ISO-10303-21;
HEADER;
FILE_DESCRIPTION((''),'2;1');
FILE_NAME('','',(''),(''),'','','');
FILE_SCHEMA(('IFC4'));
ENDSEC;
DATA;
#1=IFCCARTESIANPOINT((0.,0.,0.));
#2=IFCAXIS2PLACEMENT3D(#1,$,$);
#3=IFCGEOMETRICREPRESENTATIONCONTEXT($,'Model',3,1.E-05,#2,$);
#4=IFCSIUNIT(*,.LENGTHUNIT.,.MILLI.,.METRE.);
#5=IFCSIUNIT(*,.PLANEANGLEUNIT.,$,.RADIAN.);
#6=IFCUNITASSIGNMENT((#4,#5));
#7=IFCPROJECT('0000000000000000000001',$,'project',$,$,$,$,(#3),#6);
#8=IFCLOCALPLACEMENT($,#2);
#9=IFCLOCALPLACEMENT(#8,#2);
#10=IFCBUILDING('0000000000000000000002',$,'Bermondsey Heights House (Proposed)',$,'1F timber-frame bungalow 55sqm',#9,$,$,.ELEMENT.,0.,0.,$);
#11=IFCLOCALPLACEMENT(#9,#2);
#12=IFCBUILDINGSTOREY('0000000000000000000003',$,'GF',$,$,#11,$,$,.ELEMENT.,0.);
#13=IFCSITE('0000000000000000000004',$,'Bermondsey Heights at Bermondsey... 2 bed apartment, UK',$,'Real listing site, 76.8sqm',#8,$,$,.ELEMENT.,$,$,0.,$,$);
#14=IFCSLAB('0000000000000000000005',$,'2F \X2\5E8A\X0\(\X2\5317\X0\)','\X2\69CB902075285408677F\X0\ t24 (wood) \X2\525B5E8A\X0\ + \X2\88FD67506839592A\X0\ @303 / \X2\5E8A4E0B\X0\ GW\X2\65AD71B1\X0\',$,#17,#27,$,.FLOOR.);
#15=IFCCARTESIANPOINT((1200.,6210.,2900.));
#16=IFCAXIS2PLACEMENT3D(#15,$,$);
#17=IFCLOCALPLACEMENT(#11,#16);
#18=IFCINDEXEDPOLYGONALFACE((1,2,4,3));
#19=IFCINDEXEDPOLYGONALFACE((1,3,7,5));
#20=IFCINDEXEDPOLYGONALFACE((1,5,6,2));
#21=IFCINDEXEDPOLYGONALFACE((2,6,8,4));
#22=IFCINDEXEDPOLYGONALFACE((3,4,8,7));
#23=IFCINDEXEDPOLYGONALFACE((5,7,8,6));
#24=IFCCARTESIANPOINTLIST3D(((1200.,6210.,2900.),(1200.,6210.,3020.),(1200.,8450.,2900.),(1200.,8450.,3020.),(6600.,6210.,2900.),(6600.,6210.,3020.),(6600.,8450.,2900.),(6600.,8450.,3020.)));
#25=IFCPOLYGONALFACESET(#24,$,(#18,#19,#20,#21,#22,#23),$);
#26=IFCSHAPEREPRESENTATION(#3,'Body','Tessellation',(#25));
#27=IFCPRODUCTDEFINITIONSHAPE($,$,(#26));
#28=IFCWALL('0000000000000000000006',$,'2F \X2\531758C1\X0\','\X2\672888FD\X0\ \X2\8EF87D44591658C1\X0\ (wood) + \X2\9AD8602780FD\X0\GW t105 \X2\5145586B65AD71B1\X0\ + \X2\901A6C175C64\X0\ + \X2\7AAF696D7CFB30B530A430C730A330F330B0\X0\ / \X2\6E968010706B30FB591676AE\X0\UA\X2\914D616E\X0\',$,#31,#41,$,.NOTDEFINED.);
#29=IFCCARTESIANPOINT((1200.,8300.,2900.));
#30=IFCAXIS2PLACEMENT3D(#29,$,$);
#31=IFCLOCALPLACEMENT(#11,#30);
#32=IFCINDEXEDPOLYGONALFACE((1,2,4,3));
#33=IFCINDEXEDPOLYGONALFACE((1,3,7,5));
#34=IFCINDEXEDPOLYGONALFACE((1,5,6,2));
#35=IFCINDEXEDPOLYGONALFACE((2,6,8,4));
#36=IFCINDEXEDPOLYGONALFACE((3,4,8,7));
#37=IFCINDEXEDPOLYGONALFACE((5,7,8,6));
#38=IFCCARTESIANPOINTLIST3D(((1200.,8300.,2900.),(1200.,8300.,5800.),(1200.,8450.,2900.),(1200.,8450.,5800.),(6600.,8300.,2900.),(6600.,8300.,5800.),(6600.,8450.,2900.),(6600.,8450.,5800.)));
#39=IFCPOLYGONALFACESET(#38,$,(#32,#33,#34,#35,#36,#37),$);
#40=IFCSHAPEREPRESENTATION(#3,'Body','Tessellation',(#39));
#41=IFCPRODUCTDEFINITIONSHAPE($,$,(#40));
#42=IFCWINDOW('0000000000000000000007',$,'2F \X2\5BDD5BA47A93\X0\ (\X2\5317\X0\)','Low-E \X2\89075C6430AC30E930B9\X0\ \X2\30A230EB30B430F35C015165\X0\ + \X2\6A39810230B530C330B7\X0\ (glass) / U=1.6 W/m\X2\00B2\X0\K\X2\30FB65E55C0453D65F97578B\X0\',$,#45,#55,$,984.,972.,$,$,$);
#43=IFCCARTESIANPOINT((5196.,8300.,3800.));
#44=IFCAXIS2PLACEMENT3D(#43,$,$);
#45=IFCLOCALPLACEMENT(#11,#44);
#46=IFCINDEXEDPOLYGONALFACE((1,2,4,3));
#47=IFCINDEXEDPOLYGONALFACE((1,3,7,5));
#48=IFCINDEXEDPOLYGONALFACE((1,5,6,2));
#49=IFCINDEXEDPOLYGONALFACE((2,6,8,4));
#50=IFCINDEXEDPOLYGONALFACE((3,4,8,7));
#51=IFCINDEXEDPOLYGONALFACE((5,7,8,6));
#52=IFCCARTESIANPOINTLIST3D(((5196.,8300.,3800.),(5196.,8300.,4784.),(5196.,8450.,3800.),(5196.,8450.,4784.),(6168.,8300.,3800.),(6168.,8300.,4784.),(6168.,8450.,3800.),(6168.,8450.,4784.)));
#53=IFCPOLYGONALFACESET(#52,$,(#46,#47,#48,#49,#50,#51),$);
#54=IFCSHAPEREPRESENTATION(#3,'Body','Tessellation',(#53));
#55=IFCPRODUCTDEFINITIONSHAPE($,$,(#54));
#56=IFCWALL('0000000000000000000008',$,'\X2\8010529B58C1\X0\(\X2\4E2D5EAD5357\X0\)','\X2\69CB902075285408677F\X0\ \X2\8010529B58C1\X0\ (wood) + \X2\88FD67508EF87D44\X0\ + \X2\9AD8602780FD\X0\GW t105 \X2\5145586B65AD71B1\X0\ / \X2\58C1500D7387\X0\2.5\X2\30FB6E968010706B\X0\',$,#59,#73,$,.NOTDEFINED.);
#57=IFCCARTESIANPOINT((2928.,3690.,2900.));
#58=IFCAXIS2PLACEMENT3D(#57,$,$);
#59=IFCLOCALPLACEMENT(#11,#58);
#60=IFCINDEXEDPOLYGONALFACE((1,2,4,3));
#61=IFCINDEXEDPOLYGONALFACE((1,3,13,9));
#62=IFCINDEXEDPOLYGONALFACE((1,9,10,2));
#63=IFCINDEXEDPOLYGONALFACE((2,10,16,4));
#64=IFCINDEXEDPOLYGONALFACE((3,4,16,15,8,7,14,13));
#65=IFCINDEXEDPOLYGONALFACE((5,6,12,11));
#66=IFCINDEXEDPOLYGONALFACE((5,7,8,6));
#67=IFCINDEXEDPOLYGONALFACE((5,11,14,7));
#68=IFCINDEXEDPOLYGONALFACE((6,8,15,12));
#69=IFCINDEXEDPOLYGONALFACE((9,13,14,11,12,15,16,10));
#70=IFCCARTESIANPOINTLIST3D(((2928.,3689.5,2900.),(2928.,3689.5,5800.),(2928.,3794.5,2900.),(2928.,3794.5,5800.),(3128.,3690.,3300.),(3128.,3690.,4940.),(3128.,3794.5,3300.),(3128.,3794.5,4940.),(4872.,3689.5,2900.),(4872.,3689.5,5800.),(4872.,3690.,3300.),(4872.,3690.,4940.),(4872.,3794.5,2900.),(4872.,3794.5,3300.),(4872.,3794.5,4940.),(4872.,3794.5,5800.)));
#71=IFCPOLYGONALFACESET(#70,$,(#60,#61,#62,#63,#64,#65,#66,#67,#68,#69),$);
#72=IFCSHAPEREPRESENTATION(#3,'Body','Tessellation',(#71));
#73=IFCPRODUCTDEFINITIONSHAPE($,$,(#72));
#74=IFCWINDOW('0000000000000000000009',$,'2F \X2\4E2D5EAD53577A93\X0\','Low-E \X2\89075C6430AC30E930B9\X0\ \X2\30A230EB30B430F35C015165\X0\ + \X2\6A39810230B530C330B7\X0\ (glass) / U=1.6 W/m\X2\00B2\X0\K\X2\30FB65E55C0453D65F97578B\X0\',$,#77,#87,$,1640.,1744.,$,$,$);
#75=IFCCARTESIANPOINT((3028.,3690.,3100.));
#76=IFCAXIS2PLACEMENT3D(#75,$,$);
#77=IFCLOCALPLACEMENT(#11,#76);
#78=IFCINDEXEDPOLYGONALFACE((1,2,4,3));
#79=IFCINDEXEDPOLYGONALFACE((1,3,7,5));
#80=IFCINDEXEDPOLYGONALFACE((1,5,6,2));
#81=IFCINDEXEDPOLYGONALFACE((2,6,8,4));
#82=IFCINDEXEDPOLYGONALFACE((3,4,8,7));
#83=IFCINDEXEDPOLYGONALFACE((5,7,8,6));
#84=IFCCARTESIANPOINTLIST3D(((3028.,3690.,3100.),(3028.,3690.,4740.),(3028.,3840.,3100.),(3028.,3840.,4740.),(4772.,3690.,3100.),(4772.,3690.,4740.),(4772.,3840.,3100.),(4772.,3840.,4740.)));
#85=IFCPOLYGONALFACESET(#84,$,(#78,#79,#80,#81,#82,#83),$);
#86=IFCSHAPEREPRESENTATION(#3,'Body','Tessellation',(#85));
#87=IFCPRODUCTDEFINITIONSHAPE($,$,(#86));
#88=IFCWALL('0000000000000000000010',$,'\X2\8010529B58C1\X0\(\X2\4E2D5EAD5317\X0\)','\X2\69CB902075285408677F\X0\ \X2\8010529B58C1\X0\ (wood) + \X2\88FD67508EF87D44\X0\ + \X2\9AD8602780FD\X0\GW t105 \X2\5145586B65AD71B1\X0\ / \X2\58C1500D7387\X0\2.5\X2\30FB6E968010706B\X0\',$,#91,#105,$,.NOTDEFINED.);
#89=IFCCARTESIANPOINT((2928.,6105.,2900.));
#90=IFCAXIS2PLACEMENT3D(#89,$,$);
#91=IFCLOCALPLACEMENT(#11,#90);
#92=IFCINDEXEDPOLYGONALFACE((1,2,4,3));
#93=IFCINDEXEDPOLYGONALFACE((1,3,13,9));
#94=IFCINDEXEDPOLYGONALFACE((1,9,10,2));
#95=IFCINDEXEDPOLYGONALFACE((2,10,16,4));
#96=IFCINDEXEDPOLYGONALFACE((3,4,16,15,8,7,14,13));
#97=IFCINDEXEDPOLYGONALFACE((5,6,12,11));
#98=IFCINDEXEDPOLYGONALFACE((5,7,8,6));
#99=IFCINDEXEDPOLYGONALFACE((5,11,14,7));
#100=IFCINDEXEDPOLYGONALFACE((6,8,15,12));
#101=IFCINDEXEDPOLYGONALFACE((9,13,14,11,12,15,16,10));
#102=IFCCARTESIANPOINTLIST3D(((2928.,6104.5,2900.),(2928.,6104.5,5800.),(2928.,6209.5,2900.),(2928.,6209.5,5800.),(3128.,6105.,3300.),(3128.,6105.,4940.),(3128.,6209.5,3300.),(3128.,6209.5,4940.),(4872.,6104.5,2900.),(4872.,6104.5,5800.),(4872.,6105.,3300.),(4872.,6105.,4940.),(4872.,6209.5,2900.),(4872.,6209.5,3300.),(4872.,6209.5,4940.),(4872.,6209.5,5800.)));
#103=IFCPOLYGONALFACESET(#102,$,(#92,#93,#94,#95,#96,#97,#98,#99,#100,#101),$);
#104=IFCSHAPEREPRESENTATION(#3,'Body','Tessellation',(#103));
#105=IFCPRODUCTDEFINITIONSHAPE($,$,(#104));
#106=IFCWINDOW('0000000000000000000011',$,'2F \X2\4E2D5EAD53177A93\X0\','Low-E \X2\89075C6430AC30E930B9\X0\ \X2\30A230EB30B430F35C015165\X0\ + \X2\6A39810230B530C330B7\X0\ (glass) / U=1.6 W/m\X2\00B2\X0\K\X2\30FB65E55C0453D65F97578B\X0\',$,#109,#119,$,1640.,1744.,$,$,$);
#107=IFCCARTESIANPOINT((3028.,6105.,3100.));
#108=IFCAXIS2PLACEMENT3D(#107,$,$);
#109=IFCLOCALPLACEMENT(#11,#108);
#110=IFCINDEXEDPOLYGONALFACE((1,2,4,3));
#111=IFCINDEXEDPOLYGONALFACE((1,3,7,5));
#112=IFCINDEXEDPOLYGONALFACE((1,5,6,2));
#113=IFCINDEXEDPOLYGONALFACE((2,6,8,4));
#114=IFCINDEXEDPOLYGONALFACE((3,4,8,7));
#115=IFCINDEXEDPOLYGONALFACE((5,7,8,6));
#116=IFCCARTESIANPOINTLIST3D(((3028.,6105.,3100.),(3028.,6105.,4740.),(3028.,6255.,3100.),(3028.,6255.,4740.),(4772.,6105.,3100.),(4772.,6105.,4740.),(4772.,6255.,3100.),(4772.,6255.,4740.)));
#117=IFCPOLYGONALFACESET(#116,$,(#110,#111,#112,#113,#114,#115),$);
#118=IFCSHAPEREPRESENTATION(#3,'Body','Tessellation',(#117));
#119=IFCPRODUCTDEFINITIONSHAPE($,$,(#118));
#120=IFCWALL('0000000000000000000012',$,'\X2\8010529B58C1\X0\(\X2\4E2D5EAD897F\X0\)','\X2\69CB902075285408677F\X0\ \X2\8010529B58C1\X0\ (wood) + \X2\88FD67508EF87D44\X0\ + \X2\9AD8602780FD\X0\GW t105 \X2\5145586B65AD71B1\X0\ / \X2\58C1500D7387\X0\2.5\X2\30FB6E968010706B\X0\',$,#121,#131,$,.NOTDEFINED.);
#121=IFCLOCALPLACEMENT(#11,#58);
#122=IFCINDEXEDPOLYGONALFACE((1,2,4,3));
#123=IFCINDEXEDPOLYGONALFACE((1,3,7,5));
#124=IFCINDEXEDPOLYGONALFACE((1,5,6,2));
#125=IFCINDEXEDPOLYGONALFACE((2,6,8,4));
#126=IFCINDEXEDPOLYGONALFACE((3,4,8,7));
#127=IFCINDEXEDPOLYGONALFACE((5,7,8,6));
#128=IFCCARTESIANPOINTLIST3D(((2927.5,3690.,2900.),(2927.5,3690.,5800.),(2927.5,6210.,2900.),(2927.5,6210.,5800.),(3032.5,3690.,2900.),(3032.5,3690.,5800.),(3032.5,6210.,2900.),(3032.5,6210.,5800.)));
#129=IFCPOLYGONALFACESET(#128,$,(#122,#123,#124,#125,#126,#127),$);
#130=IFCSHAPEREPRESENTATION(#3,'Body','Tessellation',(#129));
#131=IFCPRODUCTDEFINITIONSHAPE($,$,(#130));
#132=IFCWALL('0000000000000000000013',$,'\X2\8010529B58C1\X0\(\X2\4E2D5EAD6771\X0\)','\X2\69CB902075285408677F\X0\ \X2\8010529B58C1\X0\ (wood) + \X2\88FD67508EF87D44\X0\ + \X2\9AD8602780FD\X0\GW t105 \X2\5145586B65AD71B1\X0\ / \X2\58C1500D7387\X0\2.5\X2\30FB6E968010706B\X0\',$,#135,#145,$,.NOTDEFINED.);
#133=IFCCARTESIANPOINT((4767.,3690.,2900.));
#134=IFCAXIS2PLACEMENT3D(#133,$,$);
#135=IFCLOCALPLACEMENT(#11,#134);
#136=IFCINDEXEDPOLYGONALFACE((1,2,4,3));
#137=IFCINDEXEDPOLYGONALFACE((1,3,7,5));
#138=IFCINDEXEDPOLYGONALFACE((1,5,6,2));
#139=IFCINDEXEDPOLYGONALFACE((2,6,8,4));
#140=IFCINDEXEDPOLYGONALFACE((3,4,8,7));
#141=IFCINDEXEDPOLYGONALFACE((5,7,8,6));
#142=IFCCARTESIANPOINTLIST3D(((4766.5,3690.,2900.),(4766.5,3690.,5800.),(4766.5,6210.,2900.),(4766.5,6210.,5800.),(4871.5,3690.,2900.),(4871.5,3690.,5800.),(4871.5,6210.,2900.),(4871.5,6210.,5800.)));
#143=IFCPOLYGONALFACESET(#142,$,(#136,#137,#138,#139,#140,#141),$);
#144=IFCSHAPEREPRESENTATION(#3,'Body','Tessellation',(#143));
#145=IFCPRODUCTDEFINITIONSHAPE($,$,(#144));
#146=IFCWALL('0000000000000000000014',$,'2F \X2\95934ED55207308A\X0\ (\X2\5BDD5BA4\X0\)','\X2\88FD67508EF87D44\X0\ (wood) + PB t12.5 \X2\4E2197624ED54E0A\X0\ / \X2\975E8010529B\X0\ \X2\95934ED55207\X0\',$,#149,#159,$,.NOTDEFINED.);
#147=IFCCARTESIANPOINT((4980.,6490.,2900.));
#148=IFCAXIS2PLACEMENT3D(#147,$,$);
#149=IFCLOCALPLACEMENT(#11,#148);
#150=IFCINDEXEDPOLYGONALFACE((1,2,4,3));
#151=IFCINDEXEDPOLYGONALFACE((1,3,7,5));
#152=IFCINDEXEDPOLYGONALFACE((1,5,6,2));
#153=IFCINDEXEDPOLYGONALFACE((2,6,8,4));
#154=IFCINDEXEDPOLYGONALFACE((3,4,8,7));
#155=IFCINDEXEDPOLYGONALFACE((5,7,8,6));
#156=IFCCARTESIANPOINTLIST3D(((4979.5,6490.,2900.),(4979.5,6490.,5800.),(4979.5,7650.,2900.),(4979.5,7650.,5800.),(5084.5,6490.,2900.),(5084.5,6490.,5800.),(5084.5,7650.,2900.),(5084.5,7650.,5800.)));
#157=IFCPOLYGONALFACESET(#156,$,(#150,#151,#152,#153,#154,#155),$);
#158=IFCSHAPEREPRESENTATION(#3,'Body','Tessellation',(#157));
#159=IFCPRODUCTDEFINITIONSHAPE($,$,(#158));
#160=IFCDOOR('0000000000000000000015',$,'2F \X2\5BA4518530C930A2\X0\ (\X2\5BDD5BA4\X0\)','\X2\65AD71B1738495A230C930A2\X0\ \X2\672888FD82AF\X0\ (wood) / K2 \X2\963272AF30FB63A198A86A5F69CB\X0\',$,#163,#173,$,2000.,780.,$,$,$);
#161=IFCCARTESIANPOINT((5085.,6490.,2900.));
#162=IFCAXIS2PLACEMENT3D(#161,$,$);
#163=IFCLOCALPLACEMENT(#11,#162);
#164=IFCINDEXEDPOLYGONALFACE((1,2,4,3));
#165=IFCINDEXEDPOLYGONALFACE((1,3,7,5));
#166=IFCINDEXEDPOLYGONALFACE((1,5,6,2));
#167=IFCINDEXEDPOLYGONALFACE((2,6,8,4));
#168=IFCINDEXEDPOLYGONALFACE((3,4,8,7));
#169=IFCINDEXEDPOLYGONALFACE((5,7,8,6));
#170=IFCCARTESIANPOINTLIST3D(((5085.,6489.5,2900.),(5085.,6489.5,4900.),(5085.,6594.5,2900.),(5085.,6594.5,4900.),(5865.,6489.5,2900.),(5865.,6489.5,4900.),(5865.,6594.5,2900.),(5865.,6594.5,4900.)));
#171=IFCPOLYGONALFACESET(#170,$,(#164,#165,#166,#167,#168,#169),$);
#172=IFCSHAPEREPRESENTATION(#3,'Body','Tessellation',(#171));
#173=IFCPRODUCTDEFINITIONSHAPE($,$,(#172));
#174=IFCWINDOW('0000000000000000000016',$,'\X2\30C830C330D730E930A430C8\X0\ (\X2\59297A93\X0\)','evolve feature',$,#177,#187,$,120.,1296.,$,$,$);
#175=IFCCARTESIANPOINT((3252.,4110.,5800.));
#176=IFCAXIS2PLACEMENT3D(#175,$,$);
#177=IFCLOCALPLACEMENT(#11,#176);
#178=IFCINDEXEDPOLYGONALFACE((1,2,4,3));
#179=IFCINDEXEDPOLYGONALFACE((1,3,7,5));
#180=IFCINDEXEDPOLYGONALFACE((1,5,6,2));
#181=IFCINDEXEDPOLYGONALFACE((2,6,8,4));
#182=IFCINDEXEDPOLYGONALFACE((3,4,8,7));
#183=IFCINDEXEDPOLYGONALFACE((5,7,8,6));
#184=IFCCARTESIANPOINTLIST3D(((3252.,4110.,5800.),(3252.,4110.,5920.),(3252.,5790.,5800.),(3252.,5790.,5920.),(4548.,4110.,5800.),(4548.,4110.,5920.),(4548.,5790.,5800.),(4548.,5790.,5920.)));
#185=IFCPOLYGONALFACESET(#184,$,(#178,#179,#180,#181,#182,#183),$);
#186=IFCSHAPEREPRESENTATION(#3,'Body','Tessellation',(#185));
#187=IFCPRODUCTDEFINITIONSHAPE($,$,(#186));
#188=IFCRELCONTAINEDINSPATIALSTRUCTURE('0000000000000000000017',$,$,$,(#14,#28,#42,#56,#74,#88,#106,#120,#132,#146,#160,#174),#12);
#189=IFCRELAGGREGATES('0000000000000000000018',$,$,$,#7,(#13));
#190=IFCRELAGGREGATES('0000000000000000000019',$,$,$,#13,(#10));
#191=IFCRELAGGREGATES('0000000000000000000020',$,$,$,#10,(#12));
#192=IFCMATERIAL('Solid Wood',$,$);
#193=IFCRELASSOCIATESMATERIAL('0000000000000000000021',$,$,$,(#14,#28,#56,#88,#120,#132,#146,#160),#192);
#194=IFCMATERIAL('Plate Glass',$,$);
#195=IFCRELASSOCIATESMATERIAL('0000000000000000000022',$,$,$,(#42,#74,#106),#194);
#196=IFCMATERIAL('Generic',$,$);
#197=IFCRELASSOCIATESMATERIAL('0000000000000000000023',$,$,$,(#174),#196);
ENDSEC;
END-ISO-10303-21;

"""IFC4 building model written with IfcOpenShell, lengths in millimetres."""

from ifc_helpers import new_model, si_unit, frame, frame_2d, origin, place, context, project, spatial, rectangle, extrude, material, element, fill, save


model = new_model("IFC4")

# Units and contexts
model_context = context("Model", 3, precision=1e-05, world=origin())
ifc_project = project(units=[si_unit("LENGTHUNIT", "METRE", prefix="MILLI"), si_unit("PLANEANGLEUNIT", "RADIAN")], contexts=[model_context])

# Site, building, storey
site_placement = place(None, origin())
site = spatial("IfcSite", under=ifc_project, at=site_placement, Name="Bermondsey Heights at Bermondsey... 2 bed apartment, UK", ObjectType="Real listing site, 76.8sqm", CompositionType="ELEMENT", RefElevation=0.0)
building_placement = place(site_placement, origin())
building = spatial("IfcBuilding", under=site, at=building_placement, Name="Bermondsey Heights House (Proposed)", ObjectType="1F timber-frame bungalow 55sqm", CompositionType="ELEMENT", ElevationOfRefHeight=0.0, ElevationOfTerrain=0.0)
storey_placement = place(building_placement, origin())
storey = spatial("IfcBuildingStorey", under=building, at=storey_placement, Name="GF", CompositionType="ELEMENT", Elevation=0.0)

# Slab
ifc_material_1 = material(Name="Solid Wood")
slab_placement = place(storey_placement, frame((1200.0, 6210.0, 2900.0)))
element("IfcSlab", 1, at=slab_placement, inside=storey, material=ifc_material_1, Name="2F 床(北)", Description="構造用合板 t24 (wood) 剛床 + 製材根太 @303 / 床下 GW断熱", PredefinedType="FLOOR", context=model_context, shape_type="SweptSolid", body=[
    extrude(rectangle(XDim=5400.0, YDim=2240.0, at=frame_2d((2700.0, 1120.0))), frame((1200.0, 6210.0, 2900.0)), (0.0, 0.0, 1.0), 120.0),
])

# Walls, openings, windows
wall_1_placement = place(storey_placement, frame((1200.0, 8300.0, 2900.0)))
wall_1 = element("IfcWall", 2, at=wall_1_placement, inside=storey, material=ifc_material_1, Name="2F 北壁", Description="木製 軸組外壁 (wood) + 高性能GW t105 充填断熱 + 通気層 + 窯業系サイディング / 準耐火・外皮UA配慮", PredefinedType="NOTDEFINED", context=model_context, shape_type="SweptSolid", body=[
    extrude(rectangle(XDim=5400.0, YDim=150.0, at=frame_2d((2700.0, 75.0))), frame((1200.0, 8300.0, 2900.0)), (0.0, 0.0, 1.0), 2900.0),
])
opening_1_placement = place(storey_placement, frame((5196.0, 8300.0, 3800.0)))
opening_1 = element("IfcOpeningElement", 3, at=opening_1_placement, cuts=wall_1, PredefinedType="NOTDEFINED", context=model_context, shape_type="SweptSolid", body=[
    extrude(rectangle(XDim=972.0, YDim=150.0, at=frame_2d((486.0, 75.0))), frame((5196.0, 8300.0, 3800.0)), (0.0, 0.0, 1.0), 984.0),
])
ifc_material_2 = material(Name="Plate Glass")
window_1_placement = place(storey_placement, frame((5196.0, 8300.0, 3800.0)))
window_1 = element("IfcWindow", 4, at=window_1_placement, inside=storey, material=ifc_material_2, Name="2F 寝室窓 (北)", Description="Low-E 複層ガラス アルゴン封入 + 樹脂サッシ (glass) / U=1.6 W/m²K・日射取得型", OverallHeight=984.0, OverallWidth=972.0, context=model_context, shape_type="SweptSolid", body=[
    extrude(rectangle(XDim=972.0, YDim=150.0, at=frame_2d((486.0, 75.0))), frame((5196.0, 8300.0, 3800.0)), (0.0, 0.0, 1.0), 984.0),
])
fill(opening_1, window_1)
wall_2_placement = place(storey_placement, frame((2928.0, 3690.0, 2900.0)))
wall_2 = element("IfcWall", 5, at=wall_2_placement, inside=storey, material=ifc_material_1, Name="耐力壁(中庭南)", Description="構造用合板 耐力壁 (wood) + 製材軸組 + 高性能GW t105 充填断熱 / 壁倍率2.5・準耐火", PredefinedType="NOTDEFINED", context=model_context, shape_type="SweptSolid", body=[
    extrude(rectangle(XDim=1944.0, YDim=105.0, at=frame_2d((972.0, 52.0))), frame((2928.0, 3690.0, 2900.0)), (0.0, 0.0, 1.0), 2900.0),
])
opening_2_placement = place(storey_placement, frame((3028.0, 3690.0, 3100.0)))
opening_2 = element("IfcOpeningElement", 6, at=opening_2_placement, cuts=wall_2, PredefinedType="NOTDEFINED", context=model_context, shape_type="SweptSolid", body=[
    extrude(rectangle(XDim=1744.0, YDim=150.0, at=frame_2d((872.0, 75.0))), frame((3028.0, 3690.0, 3100.0)), (0.0, 0.0, 1.0), 1640.0),
])
window_2_placement = place(storey_placement, frame((3028.0, 3690.0, 3100.0)))
window_2 = element("IfcWindow", 7, at=window_2_placement, inside=storey, material=ifc_material_2, Name="2F 中庭南窓", Description="Low-E 複層ガラス アルゴン封入 + 樹脂サッシ (glass) / U=1.6 W/m²K・日射取得型", OverallHeight=1640.0, OverallWidth=1744.0, context=model_context, shape_type="SweptSolid", body=[
    extrude(rectangle(XDim=1744.0, YDim=150.0, at=frame_2d((872.0, 75.0))), frame((3028.0, 3690.0, 3100.0)), (0.0, 0.0, 1.0), 1640.0),
])
fill(opening_2, window_2)
wall_3_placement = place(storey_placement, frame((2928.0, 6105.0, 2900.0)))
wall_3 = element("IfcWall", 8, at=wall_3_placement, inside=storey, material=ifc_material_1, Name="耐力壁(中庭北)", Description="構造用合板 耐力壁 (wood) + 製材軸組 + 高性能GW t105 充填断熱 / 壁倍率2.5・準耐火", PredefinedType="NOTDEFINED", context=model_context, shape_type="SweptSolid", body=[
    extrude(rectangle(XDim=1944.0, YDim=105.0, at=frame_2d((972.0, 52.0))), frame((2928.0, 6105.0, 2900.0)), (0.0, 0.0, 1.0), 2900.0),
])
opening_3_placement = place(storey_placement, frame((3028.0, 6105.0, 3100.0)))
opening_3 = element("IfcOpeningElement", 9, at=opening_3_placement, cuts=wall_3, PredefinedType="NOTDEFINED", context=model_context, shape_type="SweptSolid", body=[
    extrude(rectangle(XDim=1744.0, YDim=150.0, at=frame_2d((872.0, 75.0))), frame((3028.0, 6105.0, 3100.0)), (0.0, 0.0, 1.0), 1640.0),
])
window_3_placement = place(storey_placement, frame((3028.0, 6105.0, 3100.0)))
window_3 = element("IfcWindow", 10, at=window_3_placement, inside=storey, material=ifc_material_2, Name="2F 中庭北窓", Description="Low-E 複層ガラス アルゴン封入 + 樹脂サッシ (glass) / U=1.6 W/m²K・日射取得型", OverallHeight=1640.0, OverallWidth=1744.0, context=model_context, shape_type="SweptSolid", body=[
    extrude(rectangle(XDim=1744.0, YDim=150.0, at=frame_2d((872.0, 75.0))), frame((3028.0, 6105.0, 3100.0)), (0.0, 0.0, 1.0), 1640.0),
])
fill(opening_3, window_3)

# Walls
wall_4_placement = place(storey_placement, frame((2928.0, 3690.0, 2900.0)))
element("IfcWall", 11, at=wall_4_placement, inside=storey, material=ifc_material_1, Name="耐力壁(中庭西)", Description="構造用合板 耐力壁 (wood) + 製材軸組 + 高性能GW t105 充填断熱 / 壁倍率2.5・準耐火", PredefinedType="NOTDEFINED", context=model_context, shape_type="SweptSolid", body=[
    extrude(rectangle(XDim=105.0, YDim=2520.0, at=frame_2d((52.0, 1260.0))), frame((2928.0, 3690.0, 2900.0)), (0.0, 0.0, 1.0), 2900.0),
])
wall_5_placement = place(storey_placement, frame((4767.0, 3690.0, 2900.0)))
element("IfcWall", 12, at=wall_5_placement, inside=storey, material=ifc_material_1, Name="耐力壁(中庭東)", Description="構造用合板 耐力壁 (wood) + 製材軸組 + 高性能GW t105 充填断熱 / 壁倍率2.5・準耐火", PredefinedType="NOTDEFINED", context=model_context, shape_type="SweptSolid", body=[
    extrude(rectangle(XDim=105.0, YDim=2520.0, at=frame_2d((52.0, 1260.0))), frame((4767.0, 3690.0, 2900.0)), (0.0, 0.0, 1.0), 2900.0),
])
wall_6_placement = place(storey_placement, frame((4980.0, 6490.0, 2900.0)))
element("IfcWall", 13, at=wall_6_placement, inside=storey, material=ifc_material_1, Name="2F 間仕切り (寝室)", Description="製材軸組 (wood) + PB t12.5 両面仕上 / 非耐力 間仕切", PredefinedType="NOTDEFINED", context=model_context, shape_type="SweptSolid", body=[
    extrude(rectangle(XDim=105.0, YDim=1160.0, at=frame_2d((52.0, 580.0))), frame((4980.0, 6490.0, 2900.0)), (0.0, 0.0, 1.0), 2900.0),
])

# Door
door_placement = place(storey_placement, frame((5085.0, 6490.0, 2900.0)))
element("IfcDoor", 14, at=door_placement, inside=storey, material=ifc_material_1, Name="2F 室内ドア (寝室)", Description="断熱玄関ドア 木製芯 (wood) / K2 防犯・採風機構", OverallHeight=2000.0, OverallWidth=780.0, context=model_context, shape_type="SweptSolid", body=[
    extrude(rectangle(XDim=780.0, YDim=105.0, at=frame_2d((390.0, 52.0))), frame((5085.0, 6490.0, 2900.0)), (0.0, 0.0, 1.0), 2000.0),
])

# Window
ifc_material_3 = material(Name="Generic")
window_4_placement = place(storey_placement, frame((3252.0, 4110.0, 5800.0)))
element("IfcWindow", 15, at=window_4_placement, inside=storey, material=ifc_material_3, Name="トップライト (天窓)", Description="evolve feature", OverallHeight=120.0, OverallWidth=1296.0, context=model_context, shape_type="SweptSolid", body=[
    extrude(rectangle(XDim=1296.0, YDim=1680.0, at=frame_2d((648.0, 840.0))), frame((3252.0, 4110.0, 5800.0)), (0.0, 0.0, 1.0), 120.0),
])

save(model, "model.ifc")
